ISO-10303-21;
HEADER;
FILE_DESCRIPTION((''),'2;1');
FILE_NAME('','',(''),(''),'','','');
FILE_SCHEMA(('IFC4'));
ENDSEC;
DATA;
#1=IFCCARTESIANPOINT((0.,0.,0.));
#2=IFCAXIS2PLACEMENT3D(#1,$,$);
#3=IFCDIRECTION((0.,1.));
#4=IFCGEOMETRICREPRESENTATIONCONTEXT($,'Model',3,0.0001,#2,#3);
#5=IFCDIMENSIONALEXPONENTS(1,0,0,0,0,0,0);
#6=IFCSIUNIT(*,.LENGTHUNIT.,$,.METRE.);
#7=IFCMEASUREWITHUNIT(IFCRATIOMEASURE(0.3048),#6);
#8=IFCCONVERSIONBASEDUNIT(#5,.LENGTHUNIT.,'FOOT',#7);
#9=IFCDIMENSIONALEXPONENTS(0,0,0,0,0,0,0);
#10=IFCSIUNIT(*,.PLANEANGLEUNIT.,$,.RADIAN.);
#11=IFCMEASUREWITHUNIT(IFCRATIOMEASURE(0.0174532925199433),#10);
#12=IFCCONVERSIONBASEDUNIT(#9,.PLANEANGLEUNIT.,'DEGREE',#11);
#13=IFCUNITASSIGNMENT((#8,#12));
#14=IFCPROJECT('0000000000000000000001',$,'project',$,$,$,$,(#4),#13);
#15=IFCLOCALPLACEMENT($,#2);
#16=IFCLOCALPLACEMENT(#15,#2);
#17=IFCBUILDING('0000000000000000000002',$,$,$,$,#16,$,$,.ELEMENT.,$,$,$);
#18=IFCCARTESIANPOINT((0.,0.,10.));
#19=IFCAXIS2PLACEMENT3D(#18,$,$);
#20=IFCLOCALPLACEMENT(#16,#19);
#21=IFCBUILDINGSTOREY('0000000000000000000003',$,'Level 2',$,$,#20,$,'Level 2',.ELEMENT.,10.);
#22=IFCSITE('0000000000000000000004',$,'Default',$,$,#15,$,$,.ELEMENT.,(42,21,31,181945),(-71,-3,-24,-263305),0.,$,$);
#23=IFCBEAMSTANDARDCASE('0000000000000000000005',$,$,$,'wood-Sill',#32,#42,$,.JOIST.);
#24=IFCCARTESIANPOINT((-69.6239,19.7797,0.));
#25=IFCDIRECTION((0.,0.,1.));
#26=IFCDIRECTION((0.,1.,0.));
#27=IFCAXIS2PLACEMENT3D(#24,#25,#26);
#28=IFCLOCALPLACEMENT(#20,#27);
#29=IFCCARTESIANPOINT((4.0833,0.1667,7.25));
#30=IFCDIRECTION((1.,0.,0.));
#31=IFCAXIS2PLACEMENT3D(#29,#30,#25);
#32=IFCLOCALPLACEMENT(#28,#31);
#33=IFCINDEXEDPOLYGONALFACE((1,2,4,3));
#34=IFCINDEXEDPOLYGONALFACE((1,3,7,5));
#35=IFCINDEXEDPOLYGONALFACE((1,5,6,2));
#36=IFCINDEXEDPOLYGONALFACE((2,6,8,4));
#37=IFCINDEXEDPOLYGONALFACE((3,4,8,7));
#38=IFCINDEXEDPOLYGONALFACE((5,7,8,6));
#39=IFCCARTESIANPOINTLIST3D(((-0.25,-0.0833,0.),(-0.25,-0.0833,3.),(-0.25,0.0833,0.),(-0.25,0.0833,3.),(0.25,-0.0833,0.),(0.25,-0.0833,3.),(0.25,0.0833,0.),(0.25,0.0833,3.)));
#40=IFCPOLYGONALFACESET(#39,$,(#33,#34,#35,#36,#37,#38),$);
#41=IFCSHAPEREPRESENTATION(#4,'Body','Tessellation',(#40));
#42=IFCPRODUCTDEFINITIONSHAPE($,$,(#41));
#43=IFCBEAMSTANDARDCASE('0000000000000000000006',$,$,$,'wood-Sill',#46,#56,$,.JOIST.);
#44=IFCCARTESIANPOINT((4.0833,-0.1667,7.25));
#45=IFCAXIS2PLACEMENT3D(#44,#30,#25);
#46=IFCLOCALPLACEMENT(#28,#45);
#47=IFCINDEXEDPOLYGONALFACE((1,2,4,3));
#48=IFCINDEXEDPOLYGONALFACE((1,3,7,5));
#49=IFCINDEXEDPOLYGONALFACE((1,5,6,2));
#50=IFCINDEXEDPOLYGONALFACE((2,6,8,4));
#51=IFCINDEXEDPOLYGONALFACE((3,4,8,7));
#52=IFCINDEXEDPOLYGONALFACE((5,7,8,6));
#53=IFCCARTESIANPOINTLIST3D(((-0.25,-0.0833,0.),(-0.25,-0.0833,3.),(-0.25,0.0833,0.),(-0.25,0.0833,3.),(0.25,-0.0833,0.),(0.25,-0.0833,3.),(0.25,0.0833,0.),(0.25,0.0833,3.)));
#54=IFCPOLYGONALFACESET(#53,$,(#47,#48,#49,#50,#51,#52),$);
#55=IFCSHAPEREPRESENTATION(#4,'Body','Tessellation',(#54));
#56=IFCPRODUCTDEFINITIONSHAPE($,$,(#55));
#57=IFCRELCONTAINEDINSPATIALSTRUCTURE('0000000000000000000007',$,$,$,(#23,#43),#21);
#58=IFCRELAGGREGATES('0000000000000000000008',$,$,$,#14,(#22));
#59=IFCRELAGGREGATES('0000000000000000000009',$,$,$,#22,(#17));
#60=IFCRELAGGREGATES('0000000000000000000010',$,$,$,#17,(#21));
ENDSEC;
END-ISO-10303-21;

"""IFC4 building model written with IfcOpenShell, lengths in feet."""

from ifc_helpers import new_model, entity, si_unit, converted_unit, direction, frame, origin, origin_with_axes, place, context, project, spatial, rectangle, extrude, element, save


model = new_model("IFC4")

# Units and contexts
model_context = context("Model", 3, precision=0.0001, world=origin(), true_north=direction((0.0, 1.0)))
ifc_project = project(units=[converted_unit("LENGTHUNIT", "FOOT", entity("IfcRatioMeasure", 0.3048), si_unit("LENGTHUNIT", "METRE"), dimensions=[1, 0, 0, 0, 0, 0, 0]), converted_unit("PLANEANGLEUNIT", "DEGREE", entity("IfcRatioMeasure", 0.0174532925199433), si_unit("PLANEANGLEUNIT", "RADIAN"), dimensions=[0, 0, 0, 0, 0, 0, 0])], contexts=[model_context])

# Site, building, storey
site_placement = place(None, origin())
site = spatial("IfcSite", under=ifc_project, at=site_placement, Name="Default", CompositionType="ELEMENT", RefLatitude=(42, 21, 31, 181945), RefLongitude=(-71, -3, -24, -263305), RefElevation=0.0)
building_placement = place(site_placement, origin())
building = spatial("IfcBuilding", under=site, at=building_placement, CompositionType="ELEMENT")
storey_placement = place(building_placement, frame((0.0, 0.0, 10.0)))
storey = spatial("IfcBuildingStorey", under=building, at=storey_placement, Name="Level 2", LongName="Level 2", CompositionType="ELEMENT", Elevation=10.0)

# Shared definitions
placement_1 = place(storey_placement, frame((-69.6239, 19.7797, 0.0), z_axis=(0.0, 0.0, 1.0), x_axis=(0.0, 1.0, 0.0)))

# Beams
for number, where, z_axis, x_axis in (
    (1, (4.0833, 0.1667, 7.25), (1.0, 0.0, 0.0), (0.0, 0.0, 1.0)),
    (2, (4.0833, -0.1667, 7.25), (1.0, 0.0, 0.0), (0.0, 0.0, 1.0)),
):
    element("IfcBeamStandardCase", number, at=place(placement_1, frame(where, z_axis=z_axis, x_axis=x_axis)), inside=storey, ObjectType="wood-Sill", PredefinedType="JOIST", context=model_context, shape_type="SweptSolid", body=[
        extrude(rectangle(XDim=0.5, YDim=0.1667), origin_with_axes(), (0.0, 0.0, 1.0), 3.0),
    ])

save(model, "model.ifc")
